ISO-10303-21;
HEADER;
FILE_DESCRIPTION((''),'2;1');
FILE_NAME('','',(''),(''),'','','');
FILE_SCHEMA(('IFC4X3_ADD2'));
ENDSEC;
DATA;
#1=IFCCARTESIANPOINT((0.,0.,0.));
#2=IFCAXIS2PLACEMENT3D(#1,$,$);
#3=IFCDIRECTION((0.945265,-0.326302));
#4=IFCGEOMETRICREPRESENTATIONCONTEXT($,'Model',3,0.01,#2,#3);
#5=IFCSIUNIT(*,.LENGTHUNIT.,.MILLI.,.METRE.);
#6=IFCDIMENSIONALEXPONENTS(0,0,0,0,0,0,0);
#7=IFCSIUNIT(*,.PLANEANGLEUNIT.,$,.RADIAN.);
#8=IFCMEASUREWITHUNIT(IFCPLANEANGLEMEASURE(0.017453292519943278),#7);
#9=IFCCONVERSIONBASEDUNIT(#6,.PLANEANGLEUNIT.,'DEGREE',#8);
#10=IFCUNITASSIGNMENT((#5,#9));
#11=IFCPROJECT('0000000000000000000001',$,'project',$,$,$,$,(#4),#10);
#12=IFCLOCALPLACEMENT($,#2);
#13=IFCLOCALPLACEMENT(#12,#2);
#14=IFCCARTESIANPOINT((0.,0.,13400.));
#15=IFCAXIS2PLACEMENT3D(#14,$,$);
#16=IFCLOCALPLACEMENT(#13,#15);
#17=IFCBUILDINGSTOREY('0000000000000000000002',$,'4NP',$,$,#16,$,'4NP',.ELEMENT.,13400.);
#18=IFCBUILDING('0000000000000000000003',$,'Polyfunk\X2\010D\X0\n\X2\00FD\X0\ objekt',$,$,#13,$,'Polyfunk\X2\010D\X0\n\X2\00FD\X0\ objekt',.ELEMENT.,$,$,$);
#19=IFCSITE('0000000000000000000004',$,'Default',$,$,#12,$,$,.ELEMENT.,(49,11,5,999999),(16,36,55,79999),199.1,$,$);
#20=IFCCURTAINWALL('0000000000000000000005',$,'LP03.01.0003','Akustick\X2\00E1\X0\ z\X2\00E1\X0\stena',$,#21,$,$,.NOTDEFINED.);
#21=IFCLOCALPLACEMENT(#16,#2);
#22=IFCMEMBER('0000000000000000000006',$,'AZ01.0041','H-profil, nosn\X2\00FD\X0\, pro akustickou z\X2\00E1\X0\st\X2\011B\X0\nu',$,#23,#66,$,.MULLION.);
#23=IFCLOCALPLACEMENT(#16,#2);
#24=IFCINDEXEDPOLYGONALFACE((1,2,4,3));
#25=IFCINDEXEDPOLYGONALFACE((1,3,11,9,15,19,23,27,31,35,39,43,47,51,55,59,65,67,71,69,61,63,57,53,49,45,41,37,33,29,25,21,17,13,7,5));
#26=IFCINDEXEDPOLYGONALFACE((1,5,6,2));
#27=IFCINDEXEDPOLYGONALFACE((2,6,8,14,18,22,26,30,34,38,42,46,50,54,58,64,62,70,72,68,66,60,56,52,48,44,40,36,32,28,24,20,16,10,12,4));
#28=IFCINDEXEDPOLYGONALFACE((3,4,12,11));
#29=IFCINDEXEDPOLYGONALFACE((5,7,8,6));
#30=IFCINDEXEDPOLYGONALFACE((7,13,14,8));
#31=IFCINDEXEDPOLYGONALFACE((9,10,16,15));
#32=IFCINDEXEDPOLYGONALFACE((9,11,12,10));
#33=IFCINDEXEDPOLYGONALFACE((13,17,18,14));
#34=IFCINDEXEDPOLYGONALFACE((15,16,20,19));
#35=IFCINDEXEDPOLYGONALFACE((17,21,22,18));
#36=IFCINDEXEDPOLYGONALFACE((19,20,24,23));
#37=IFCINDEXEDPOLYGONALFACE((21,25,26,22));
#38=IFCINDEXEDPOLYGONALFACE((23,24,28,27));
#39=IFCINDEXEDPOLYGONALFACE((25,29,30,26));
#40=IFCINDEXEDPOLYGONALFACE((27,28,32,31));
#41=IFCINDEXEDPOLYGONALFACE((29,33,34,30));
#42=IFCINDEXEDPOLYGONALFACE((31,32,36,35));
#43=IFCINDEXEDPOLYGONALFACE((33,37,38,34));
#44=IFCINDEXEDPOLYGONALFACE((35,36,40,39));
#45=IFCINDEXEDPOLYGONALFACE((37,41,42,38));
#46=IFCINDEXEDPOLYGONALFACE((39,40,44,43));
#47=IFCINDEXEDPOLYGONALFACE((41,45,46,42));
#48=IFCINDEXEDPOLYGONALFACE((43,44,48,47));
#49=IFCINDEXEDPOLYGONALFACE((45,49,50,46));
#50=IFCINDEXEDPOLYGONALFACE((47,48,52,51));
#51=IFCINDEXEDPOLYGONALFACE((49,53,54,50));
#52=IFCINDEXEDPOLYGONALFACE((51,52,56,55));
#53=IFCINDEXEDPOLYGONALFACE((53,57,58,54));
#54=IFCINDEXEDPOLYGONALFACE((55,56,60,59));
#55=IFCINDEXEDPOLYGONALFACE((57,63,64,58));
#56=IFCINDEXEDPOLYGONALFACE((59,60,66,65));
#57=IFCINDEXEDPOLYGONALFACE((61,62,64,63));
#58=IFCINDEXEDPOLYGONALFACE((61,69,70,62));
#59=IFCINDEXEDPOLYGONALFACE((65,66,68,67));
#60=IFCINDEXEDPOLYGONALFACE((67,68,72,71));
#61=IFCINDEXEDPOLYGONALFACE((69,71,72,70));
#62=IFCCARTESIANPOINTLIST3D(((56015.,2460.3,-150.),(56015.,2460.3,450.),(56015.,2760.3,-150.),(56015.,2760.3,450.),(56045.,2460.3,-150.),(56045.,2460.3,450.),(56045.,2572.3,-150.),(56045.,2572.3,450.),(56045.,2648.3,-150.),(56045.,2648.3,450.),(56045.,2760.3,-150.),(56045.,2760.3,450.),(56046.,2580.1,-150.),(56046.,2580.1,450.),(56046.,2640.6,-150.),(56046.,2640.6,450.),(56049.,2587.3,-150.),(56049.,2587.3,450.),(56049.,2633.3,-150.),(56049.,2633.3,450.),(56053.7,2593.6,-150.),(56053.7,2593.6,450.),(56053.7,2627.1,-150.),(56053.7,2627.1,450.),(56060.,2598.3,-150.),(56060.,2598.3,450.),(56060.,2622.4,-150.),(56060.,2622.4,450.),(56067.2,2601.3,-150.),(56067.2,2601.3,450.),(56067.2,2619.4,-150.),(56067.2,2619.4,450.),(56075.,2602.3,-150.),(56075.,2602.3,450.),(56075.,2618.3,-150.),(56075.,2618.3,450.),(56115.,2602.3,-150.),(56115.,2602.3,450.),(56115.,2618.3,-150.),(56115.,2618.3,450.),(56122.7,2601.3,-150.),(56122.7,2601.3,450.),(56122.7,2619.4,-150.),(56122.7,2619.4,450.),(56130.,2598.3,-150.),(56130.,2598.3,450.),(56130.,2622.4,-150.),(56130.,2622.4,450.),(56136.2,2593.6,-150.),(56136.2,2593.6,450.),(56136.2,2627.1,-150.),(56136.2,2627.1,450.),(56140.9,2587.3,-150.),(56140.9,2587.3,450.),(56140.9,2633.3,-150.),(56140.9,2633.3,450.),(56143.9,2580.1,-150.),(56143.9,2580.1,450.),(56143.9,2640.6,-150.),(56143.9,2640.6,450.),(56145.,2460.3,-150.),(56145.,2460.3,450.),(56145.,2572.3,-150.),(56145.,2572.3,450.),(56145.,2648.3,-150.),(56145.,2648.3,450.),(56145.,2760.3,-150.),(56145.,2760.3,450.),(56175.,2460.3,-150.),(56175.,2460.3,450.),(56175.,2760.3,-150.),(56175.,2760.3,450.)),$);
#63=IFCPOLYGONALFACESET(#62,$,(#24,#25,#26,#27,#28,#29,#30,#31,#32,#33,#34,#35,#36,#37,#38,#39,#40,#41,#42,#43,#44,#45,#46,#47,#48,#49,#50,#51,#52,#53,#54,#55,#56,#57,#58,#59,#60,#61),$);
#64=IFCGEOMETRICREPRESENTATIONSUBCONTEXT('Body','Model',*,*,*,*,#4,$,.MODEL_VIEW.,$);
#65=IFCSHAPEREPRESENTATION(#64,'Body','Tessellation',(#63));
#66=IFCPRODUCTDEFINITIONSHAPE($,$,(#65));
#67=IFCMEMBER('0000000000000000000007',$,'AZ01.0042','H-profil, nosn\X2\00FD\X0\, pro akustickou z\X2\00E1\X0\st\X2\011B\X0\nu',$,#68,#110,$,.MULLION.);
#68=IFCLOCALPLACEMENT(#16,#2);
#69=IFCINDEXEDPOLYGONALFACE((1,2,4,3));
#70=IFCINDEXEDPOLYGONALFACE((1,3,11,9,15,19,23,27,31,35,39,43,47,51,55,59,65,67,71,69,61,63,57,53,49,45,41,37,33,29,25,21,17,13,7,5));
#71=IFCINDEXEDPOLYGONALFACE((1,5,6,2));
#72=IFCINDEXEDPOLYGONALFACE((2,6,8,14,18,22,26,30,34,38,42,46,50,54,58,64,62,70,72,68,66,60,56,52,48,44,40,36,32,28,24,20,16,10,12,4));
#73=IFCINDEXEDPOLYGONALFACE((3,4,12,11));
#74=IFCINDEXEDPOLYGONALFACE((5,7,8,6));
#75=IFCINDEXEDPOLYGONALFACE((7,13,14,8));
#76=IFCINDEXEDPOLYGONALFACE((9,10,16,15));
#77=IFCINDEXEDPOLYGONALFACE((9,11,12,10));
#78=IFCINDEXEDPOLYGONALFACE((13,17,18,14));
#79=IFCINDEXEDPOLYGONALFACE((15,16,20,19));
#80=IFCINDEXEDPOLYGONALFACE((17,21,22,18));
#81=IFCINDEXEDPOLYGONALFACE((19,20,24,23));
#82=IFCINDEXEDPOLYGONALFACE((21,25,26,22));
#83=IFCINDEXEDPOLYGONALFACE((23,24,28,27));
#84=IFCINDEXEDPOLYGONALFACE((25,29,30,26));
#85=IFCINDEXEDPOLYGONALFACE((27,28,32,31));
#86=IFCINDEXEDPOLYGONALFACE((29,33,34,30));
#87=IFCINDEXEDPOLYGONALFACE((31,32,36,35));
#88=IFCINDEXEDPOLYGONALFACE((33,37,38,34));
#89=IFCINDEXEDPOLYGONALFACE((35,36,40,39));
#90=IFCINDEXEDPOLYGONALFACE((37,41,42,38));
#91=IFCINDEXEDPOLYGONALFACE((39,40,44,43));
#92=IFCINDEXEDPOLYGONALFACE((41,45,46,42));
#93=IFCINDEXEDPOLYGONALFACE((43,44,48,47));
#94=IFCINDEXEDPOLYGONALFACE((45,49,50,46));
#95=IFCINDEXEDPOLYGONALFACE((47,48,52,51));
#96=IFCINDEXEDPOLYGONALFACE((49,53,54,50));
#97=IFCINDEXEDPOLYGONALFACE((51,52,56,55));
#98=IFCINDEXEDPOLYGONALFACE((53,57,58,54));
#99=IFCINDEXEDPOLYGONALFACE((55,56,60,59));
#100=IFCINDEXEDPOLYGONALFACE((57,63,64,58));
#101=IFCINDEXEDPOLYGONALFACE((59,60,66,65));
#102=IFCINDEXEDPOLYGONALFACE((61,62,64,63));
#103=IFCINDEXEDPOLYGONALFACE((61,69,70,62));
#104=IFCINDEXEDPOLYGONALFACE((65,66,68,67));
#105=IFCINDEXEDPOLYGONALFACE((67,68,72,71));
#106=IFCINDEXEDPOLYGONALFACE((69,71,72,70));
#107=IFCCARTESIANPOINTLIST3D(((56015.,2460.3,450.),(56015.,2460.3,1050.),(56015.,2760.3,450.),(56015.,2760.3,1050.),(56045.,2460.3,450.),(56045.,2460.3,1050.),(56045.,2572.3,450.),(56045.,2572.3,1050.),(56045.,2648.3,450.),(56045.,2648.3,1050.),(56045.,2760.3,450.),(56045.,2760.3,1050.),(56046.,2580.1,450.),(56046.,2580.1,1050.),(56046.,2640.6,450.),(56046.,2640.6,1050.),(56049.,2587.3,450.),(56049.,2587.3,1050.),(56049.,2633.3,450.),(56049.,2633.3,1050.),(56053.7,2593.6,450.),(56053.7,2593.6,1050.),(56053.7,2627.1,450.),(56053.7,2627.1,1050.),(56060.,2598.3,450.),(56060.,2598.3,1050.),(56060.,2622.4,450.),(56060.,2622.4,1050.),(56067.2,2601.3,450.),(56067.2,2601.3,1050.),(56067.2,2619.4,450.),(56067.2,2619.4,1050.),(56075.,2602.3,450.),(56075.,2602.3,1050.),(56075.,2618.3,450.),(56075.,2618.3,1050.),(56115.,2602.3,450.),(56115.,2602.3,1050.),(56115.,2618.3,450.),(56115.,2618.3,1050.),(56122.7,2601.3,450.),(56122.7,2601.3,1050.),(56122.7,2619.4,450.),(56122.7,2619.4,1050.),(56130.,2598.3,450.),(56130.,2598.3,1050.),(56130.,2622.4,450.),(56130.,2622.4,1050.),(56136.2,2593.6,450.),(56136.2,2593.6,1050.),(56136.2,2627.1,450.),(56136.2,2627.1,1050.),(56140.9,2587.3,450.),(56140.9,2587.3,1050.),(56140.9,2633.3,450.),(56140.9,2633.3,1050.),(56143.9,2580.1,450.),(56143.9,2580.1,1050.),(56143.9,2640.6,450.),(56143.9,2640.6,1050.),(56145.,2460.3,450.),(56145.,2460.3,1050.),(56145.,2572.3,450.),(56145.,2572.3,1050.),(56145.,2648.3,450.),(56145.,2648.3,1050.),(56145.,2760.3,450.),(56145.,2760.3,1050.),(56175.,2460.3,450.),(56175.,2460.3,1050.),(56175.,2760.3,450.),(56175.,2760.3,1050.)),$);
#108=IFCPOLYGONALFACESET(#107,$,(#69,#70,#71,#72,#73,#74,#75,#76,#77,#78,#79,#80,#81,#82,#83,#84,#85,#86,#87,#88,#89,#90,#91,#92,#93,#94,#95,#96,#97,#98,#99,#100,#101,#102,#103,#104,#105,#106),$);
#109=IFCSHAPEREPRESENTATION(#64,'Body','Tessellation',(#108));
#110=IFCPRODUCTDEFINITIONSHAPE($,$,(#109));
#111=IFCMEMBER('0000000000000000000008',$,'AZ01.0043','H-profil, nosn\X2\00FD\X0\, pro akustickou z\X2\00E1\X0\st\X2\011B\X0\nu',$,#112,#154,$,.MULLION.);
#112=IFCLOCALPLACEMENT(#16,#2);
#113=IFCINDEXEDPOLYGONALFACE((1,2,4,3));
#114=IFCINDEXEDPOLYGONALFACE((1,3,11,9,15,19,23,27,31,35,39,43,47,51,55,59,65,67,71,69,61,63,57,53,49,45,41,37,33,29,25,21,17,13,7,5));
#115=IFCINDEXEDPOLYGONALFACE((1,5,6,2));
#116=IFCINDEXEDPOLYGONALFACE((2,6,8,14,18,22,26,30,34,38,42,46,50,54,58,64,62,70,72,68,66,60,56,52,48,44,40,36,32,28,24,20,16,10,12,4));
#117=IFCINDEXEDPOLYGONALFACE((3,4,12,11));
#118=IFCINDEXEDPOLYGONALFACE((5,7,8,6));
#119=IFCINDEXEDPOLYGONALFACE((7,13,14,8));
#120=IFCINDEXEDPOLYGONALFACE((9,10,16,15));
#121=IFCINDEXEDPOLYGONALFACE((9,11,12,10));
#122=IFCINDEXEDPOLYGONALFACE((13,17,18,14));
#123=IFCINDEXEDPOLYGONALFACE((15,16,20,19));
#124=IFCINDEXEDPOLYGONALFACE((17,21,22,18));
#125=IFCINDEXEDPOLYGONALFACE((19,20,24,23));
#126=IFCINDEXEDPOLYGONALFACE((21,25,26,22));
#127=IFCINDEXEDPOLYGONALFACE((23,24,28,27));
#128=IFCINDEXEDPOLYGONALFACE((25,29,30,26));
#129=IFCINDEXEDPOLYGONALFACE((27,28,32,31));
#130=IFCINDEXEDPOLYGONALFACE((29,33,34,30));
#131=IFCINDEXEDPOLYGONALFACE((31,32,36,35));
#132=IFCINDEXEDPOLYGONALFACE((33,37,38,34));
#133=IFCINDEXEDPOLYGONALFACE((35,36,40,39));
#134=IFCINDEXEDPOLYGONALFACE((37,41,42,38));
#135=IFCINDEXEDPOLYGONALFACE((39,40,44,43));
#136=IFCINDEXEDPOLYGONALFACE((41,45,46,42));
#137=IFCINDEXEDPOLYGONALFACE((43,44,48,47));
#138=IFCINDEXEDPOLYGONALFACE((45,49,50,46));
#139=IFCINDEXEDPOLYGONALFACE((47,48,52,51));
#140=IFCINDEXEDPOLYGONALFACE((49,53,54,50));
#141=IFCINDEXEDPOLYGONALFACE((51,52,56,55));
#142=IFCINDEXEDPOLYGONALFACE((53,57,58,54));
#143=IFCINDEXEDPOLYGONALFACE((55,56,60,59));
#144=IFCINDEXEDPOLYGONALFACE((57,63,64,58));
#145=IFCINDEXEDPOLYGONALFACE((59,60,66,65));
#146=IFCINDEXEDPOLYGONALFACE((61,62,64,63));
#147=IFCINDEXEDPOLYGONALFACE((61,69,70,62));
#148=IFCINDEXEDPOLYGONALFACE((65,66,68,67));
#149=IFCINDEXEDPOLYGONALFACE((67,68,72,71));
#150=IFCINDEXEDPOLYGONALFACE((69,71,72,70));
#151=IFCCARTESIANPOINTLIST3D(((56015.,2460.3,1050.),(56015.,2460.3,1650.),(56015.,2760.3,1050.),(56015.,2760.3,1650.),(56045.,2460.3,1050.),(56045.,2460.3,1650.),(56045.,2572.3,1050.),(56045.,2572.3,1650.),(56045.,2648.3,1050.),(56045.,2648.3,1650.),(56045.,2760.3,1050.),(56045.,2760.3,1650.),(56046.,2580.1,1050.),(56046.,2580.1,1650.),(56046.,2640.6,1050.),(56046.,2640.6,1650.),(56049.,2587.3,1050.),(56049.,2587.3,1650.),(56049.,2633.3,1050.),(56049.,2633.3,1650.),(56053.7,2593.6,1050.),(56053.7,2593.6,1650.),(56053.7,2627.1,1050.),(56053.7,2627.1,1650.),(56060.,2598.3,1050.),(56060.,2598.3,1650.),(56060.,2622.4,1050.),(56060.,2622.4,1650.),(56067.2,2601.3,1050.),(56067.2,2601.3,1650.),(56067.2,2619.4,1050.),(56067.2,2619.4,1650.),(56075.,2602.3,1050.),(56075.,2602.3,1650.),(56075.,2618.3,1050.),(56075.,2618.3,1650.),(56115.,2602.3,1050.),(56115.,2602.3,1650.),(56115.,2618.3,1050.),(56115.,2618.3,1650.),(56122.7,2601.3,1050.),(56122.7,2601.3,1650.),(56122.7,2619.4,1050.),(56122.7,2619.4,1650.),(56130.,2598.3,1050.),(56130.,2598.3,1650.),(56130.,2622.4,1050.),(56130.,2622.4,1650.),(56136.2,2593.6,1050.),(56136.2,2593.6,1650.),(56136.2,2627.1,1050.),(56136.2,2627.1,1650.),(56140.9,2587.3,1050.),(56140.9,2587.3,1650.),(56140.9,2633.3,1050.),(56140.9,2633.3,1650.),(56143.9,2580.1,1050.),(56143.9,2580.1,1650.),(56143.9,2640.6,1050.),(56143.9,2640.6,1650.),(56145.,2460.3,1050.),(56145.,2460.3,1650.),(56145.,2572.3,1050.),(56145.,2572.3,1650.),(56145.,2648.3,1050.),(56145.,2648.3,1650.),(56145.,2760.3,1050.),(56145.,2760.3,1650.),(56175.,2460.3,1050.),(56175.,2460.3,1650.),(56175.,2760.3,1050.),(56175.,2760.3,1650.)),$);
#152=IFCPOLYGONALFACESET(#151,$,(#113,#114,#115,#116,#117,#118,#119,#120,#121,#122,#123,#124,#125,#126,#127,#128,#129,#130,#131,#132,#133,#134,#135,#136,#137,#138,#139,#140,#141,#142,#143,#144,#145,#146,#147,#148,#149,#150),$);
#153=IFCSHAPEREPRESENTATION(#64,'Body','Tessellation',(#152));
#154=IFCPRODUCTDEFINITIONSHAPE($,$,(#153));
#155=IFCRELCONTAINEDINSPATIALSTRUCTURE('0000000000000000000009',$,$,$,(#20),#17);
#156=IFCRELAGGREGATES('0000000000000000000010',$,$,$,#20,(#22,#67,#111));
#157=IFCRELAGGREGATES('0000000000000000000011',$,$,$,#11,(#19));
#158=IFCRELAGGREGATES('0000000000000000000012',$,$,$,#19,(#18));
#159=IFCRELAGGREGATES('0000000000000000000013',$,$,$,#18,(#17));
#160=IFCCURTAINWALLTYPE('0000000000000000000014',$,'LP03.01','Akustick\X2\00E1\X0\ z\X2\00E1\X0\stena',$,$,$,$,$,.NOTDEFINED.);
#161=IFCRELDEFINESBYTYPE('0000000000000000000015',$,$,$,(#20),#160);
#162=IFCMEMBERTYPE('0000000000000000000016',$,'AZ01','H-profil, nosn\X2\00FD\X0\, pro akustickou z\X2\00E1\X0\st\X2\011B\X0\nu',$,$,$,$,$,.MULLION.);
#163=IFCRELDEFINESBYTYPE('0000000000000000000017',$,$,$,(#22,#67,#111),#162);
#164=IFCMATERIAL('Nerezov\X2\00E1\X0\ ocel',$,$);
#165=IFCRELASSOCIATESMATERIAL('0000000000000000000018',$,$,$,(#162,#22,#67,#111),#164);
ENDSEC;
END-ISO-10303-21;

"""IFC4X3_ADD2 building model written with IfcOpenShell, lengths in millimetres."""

from ifc_helpers import new_model, entity, si_unit, converted_unit, direction, frame, frame_2d, origin, place, context, subcontext, project, spatial, polyline, circle_curve, parameter, trimmed, segment, composite_curve, outline, extrude, source, transform, mapped, material, material_profile, profile_set, profile_usage, type_object, element, aggregate, save


model = new_model("IFC4X3_ADD2")

# Units and contexts
model_context = context("Model", 3, precision=0.01, world=origin(), true_north=direction((0.945265, -0.326302)))
body_context = subcontext(model_context, "Body", "Model", "MODEL_VIEW")
ifc_project = project(units=[si_unit("LENGTHUNIT", "METRE", prefix="MILLI"), converted_unit("PLANEANGLEUNIT", "DEGREE", entity("IfcPlaneAngleMeasure", 0.017453292519943278), si_unit("PLANEANGLEUNIT", "RADIAN"), dimensions=[0, 0, 0, 0, 0, 0, 0])], contexts=[model_context])

# Site, building, storey
site_placement = place(None, origin())
site = spatial("IfcSite", under=ifc_project, at=site_placement, Name="Default", CompositionType="ELEMENT", RefLatitude=(49, 11, 5, 999999), RefLongitude=(16, 36, 55, 79999), RefElevation=199.1)
building_placement = place(site_placement, origin())
building = spatial("IfcBuilding", under=site, at=building_placement, Name="Polyfunkčný objekt", LongName="Polyfunkčný objekt", CompositionType="ELEMENT")
storey_placement = place(building_placement, frame((0.0, 0.0, 13400.0)))
storey = spatial("IfcBuildingStorey", under=building, at=storey_placement, Name="4NP", LongName="4NP", CompositionType="ELEMENT", Elevation=13400.0)

# Curtain wall, members
curtain_wall_type = type_object("IfcCurtainWallType", Name="LP03.01", Description="Akustická zástena", PredefinedType="NOTDEFINED")
curtain_wall_1_placement = place(storey_placement, frame((0.0, 0.0, -13400.0)))
curtain_wall_1 = element("IfcCurtainWall", 1, at=curtain_wall_1_placement, inside=storey, type_object=curtain_wall_type, Name="LP03.01.0003", Description="Akustická zástena", PredefinedType="NOTDEFINED")
ifc_material_1 = material(Name="Nerezová ocel")
ifc_material_profile = material_profile(ifc_material_1, outline(composite_curve([segment(polyline([(50.0, -150.0), (80.0, -150.0)]), True, "CONTINUOUS"), segment(polyline([(80.0, -150.0), (80.0, 150.0)]), True, "CONTINUOUS"), segment(polyline([(80.0, 150.0), (50.0, 150.0)]), True, "CONTINUOUS"), segment(polyline([(50.0, 150.0), (50.0, 38.0)]), True, "CONTINUOUS"), segment(trimmed(circle_curve(frame_2d((20.0, 38.0), x_axis=(0.0, 1.0)), 30.0), [parameter(180.0)], [parameter(270.0)], True, "PARAMETER"), False, "CONTINUOUS"), segment(polyline([(20.0, 8.0), (-20.0, 8.0)]), True, "CONTINUOUS"), segment(trimmed(circle_curve(frame_2d((-20.0, 38.0), x_axis=(0.0, 1.0)), 30.0), [parameter(90.0)], [parameter(180.0)], True, "PARAMETER"), False, "CONTINUOUS"), segment(polyline([(-50.0, 38.0), (-50.0, 150.0)]), True, "CONTINUOUS"), segment(polyline([(-50.0, 150.0), (-80.0, 150.0)]), True, "CONTINUOUS"), segment(polyline([(-80.0, 150.0), (-80.0, -150.0)]), True, "CONTINUOUS"), segment(polyline([(-80.0, -150.0), (-50.0, -150.0)]), True, "CONTINUOUS"), segment(polyline([(-50.0, -150.0), (-50.0, -38.0)]), True, "CONTINUOUS"), segment(trimmed(circle_curve(frame_2d((-20.0, -38.0), x_axis=(0.0, 1.0)), 30.0), [parameter(0.0)], [parameter(90.0)], True, "PARAMETER"), False, "CONTINUOUS"), segment(polyline([(-20.0, -8.0), (20.0, -8.0)]), True, "CONTINUOUS"), segment(trimmed(circle_curve(frame_2d((20.0, -38.0), x_axis=(0.0, 1.0)), 30.0), [parameter(270.0)], [parameter(0.0)], True, "PARAMETER"), False, "CONTINUOUS"), segment(polyline([(50.0, -38.0), (50.0, -150.0)]), True, "CONTINUOUS")], self_intersect=False)), Name="Profil zástena")
ifc_profile_set = profile_set([ifc_material_profile], Name="Profil zástena")
ifc_profile_usage = profile_usage(ifc_profile_set)
member_type = type_object("IfcMemberType", Name="AZ01", Description="H-profil, nosný, pro akustickou zástěnu", PredefinedType="MULLION", material=ifc_profile_set)
shared_shape_1 = source(origin(), body_context, "Body", "SweptSolid", [
    extrude(outline(composite_curve([segment(polyline([(-150.0, -50.0), (-150.0, -80.0)]), True, "CONTINUOUS"), segment(polyline([(-150.0, -80.0), (150.0, -80.0)]), True, "CONTINUOUS"), segment(polyline([(150.0, -80.0), (150.0, -50.0)]), True, "CONTINUOUS"), segment(polyline([(150.0, -50.0), (38.0, -50.0)]), True, "CONTINUOUS"), segment(trimmed(circle_curve(frame_2d((38.0, -20.0), x_axis=(1.0, 0.0)), 30.0), [parameter(180.0)], [parameter(270.0)], True, "PARAMETER"), False, "CONTINUOUS"), segment(polyline([(8.0, -20.0), (8.0, 20.0)]), True, "CONTINUOUS"), segment(trimmed(circle_curve(frame_2d((38.0, 20.0), x_axis=(1.0, 0.0)), 30.0), [parameter(90.0)], [parameter(180.0)], True, "PARAMETER"), False, "CONTINUOUS"), segment(polyline([(38.0, 50.0), (150.0, 50.0)]), True, "CONTINUOUS"), segment(polyline([(150.0, 50.0), (150.0, 80.0)]), True, "CONTINUOUS"), segment(polyline([(150.0, 80.0), (-150.0, 80.0)]), True, "CONTINUOUS"), segment(polyline([(-150.0, 80.0), (-150.0, 50.0)]), True, "CONTINUOUS"), segment(polyline([(-150.0, 50.0), (-38.0, 50.0)]), True, "CONTINUOUS"), segment(trimmed(circle_curve(frame_2d((-38.0, 20.0), x_axis=(1.0, 0.0)), 30.0), [parameter(0.0)], [parameter(90.0)], True, "PARAMETER"), False, "CONTINUOUS"), segment(polyline([(-8.0, 20.0), (-8.0, -20.0)]), True, "CONTINUOUS"), segment(trimmed(circle_curve(frame_2d((-38.0, -20.0), x_axis=(1.0, 0.0)), 30.0), [parameter(270.0)], [parameter(0.0)], True, "PARAMETER"), False, "CONTINUOUS"), segment(polyline([(-38.0, -50.0), (-150.0, -50.0)]), True, "CONTINUOUS")], self_intersect=False)), frame((0.0, 0.0, -600.0), z_axis=(0.0, 0.0, -1.0), x_axis=(1.0, 0.0, 0.0)), (0.0, 0.0, -1.0), 600.0),
])
member_1_placement = place(curtain_wall_1_placement, frame((56095.0, 2610.3, 13250.0), z_axis=(0.0, 0.0, -1.0), x_axis=(0.0, 1.0, 0.0)))
member_1 = element("IfcMember", 2, at=member_1_placement, type_object=member_type, material=ifc_profile_usage, Name="AZ01.0041", Description="H-profil, nosný, pro akustickou zástěnu", PredefinedType="MULLION", context=body_context, shape_type="MappedRepresentation", body=[
    mapped(shared_shape_1, transform((0.0, 0.0, 0.0), scale=1.0)),
])
shared_shape_2 = source(origin(), body_context, "Body", "SweptSolid", [
    extrude(outline(composite_curve([segment(polyline([(-150.0, -50.0), (-150.0, -80.0)]), True, "CONTINUOUS"), segment(polyline([(-150.0, -80.0), (150.0, -80.0)]), True, "CONTINUOUS"), segment(polyline([(150.0, -80.0), (150.0, -50.0)]), True, "CONTINUOUS"), segment(polyline([(150.0, -50.0), (38.0, -50.0)]), True, "CONTINUOUS"), segment(trimmed(circle_curve(frame_2d((38.0, -20.0), x_axis=(1.0, 0.0)), 30.0), [parameter(180.0)], [parameter(270.0)], True, "PARAMETER"), False, "CONTINUOUS"), segment(polyline([(8.0, -20.0), (8.0, 20.0)]), True, "CONTINUOUS"), segment(trimmed(circle_curve(frame_2d((38.0, 20.0), x_axis=(1.0, 0.0)), 30.0), [parameter(90.0)], [parameter(180.0)], True, "PARAMETER"), False, "CONTINUOUS"), segment(polyline([(38.0, 50.0), (150.0, 50.0)]), True, "CONTINUOUS"), segment(polyline([(150.0, 50.0), (150.0, 80.0)]), True, "CONTINUOUS"), segment(polyline([(150.0, 80.0), (-150.0, 80.0)]), True, "CONTINUOUS"), segment(polyline([(-150.0, 80.0), (-150.0, 50.0)]), True, "CONTINUOUS"), segment(polyline([(-150.0, 50.0), (-38.0, 50.0)]), True, "CONTINUOUS"), segment(trimmed(circle_curve(frame_2d((-38.0, 20.0), x_axis=(1.0, 0.0)), 30.0), [parameter(0.0)], [parameter(90.0)], True, "PARAMETER"), False, "CONTINUOUS"), segment(polyline([(-8.0, 20.0), (-8.0, -20.0)]), True, "CONTINUOUS"), segment(trimmed(circle_curve(frame_2d((-38.0, -20.0), x_axis=(1.0, 0.0)), 30.0), [parameter(270.0)], [parameter(0.0)], True, "PARAMETER"), False, "CONTINUOUS"), segment(polyline([(-38.0, -50.0), (-150.0, -50.0)]), True, "CONTINUOUS")], self_intersect=False)), frame((0.0, 0.0, -600.0), z_axis=(0.0, 0.0, -1.0), x_axis=(1.0, 0.0, 0.0)), (0.0, 0.0, -1.0), 600.0),
])
member_2_placement = place(curtain_wall_1_placement, frame((56095.0, 2610.3, 13850.0), z_axis=(0.0, 0.0, -1.0), x_axis=(0.0, 1.0, 0.0)))
member_2 = element("IfcMember", 3, at=member_2_placement, type_object=member_type, material=ifc_profile_usage, Name="AZ01.0042", Description="H-profil, nosný, pro akustickou zástěnu", PredefinedType="MULLION", context=body_context, shape_type="MappedRepresentation", body=[
    mapped(shared_shape_2, transform((0.0, 0.0, 0.0), scale=1.0)),
])
member_3_placement = place(curtain_wall_1_placement, frame((56095.0, 2610.3, 14450.0), z_axis=(0.0, 0.0, -1.0), x_axis=(0.0, 1.0, 0.0)))
member_3 = element("IfcMember", 4, at=member_3_placement, type_object=member_type, material=ifc_profile_usage, Name="AZ01.0043", Description="H-profil, nosný, pro akustickou zástěnu", PredefinedType="MULLION", context=body_context, shape_type="MappedRepresentation", body=[
    mapped(shared_shape_2, transform((0.0, 0.0, 0.0), scale=1.0)),
])

aggregate(curtain_wall_1, [member_1, member_2, member_3])

save(model, "model.ifc")
